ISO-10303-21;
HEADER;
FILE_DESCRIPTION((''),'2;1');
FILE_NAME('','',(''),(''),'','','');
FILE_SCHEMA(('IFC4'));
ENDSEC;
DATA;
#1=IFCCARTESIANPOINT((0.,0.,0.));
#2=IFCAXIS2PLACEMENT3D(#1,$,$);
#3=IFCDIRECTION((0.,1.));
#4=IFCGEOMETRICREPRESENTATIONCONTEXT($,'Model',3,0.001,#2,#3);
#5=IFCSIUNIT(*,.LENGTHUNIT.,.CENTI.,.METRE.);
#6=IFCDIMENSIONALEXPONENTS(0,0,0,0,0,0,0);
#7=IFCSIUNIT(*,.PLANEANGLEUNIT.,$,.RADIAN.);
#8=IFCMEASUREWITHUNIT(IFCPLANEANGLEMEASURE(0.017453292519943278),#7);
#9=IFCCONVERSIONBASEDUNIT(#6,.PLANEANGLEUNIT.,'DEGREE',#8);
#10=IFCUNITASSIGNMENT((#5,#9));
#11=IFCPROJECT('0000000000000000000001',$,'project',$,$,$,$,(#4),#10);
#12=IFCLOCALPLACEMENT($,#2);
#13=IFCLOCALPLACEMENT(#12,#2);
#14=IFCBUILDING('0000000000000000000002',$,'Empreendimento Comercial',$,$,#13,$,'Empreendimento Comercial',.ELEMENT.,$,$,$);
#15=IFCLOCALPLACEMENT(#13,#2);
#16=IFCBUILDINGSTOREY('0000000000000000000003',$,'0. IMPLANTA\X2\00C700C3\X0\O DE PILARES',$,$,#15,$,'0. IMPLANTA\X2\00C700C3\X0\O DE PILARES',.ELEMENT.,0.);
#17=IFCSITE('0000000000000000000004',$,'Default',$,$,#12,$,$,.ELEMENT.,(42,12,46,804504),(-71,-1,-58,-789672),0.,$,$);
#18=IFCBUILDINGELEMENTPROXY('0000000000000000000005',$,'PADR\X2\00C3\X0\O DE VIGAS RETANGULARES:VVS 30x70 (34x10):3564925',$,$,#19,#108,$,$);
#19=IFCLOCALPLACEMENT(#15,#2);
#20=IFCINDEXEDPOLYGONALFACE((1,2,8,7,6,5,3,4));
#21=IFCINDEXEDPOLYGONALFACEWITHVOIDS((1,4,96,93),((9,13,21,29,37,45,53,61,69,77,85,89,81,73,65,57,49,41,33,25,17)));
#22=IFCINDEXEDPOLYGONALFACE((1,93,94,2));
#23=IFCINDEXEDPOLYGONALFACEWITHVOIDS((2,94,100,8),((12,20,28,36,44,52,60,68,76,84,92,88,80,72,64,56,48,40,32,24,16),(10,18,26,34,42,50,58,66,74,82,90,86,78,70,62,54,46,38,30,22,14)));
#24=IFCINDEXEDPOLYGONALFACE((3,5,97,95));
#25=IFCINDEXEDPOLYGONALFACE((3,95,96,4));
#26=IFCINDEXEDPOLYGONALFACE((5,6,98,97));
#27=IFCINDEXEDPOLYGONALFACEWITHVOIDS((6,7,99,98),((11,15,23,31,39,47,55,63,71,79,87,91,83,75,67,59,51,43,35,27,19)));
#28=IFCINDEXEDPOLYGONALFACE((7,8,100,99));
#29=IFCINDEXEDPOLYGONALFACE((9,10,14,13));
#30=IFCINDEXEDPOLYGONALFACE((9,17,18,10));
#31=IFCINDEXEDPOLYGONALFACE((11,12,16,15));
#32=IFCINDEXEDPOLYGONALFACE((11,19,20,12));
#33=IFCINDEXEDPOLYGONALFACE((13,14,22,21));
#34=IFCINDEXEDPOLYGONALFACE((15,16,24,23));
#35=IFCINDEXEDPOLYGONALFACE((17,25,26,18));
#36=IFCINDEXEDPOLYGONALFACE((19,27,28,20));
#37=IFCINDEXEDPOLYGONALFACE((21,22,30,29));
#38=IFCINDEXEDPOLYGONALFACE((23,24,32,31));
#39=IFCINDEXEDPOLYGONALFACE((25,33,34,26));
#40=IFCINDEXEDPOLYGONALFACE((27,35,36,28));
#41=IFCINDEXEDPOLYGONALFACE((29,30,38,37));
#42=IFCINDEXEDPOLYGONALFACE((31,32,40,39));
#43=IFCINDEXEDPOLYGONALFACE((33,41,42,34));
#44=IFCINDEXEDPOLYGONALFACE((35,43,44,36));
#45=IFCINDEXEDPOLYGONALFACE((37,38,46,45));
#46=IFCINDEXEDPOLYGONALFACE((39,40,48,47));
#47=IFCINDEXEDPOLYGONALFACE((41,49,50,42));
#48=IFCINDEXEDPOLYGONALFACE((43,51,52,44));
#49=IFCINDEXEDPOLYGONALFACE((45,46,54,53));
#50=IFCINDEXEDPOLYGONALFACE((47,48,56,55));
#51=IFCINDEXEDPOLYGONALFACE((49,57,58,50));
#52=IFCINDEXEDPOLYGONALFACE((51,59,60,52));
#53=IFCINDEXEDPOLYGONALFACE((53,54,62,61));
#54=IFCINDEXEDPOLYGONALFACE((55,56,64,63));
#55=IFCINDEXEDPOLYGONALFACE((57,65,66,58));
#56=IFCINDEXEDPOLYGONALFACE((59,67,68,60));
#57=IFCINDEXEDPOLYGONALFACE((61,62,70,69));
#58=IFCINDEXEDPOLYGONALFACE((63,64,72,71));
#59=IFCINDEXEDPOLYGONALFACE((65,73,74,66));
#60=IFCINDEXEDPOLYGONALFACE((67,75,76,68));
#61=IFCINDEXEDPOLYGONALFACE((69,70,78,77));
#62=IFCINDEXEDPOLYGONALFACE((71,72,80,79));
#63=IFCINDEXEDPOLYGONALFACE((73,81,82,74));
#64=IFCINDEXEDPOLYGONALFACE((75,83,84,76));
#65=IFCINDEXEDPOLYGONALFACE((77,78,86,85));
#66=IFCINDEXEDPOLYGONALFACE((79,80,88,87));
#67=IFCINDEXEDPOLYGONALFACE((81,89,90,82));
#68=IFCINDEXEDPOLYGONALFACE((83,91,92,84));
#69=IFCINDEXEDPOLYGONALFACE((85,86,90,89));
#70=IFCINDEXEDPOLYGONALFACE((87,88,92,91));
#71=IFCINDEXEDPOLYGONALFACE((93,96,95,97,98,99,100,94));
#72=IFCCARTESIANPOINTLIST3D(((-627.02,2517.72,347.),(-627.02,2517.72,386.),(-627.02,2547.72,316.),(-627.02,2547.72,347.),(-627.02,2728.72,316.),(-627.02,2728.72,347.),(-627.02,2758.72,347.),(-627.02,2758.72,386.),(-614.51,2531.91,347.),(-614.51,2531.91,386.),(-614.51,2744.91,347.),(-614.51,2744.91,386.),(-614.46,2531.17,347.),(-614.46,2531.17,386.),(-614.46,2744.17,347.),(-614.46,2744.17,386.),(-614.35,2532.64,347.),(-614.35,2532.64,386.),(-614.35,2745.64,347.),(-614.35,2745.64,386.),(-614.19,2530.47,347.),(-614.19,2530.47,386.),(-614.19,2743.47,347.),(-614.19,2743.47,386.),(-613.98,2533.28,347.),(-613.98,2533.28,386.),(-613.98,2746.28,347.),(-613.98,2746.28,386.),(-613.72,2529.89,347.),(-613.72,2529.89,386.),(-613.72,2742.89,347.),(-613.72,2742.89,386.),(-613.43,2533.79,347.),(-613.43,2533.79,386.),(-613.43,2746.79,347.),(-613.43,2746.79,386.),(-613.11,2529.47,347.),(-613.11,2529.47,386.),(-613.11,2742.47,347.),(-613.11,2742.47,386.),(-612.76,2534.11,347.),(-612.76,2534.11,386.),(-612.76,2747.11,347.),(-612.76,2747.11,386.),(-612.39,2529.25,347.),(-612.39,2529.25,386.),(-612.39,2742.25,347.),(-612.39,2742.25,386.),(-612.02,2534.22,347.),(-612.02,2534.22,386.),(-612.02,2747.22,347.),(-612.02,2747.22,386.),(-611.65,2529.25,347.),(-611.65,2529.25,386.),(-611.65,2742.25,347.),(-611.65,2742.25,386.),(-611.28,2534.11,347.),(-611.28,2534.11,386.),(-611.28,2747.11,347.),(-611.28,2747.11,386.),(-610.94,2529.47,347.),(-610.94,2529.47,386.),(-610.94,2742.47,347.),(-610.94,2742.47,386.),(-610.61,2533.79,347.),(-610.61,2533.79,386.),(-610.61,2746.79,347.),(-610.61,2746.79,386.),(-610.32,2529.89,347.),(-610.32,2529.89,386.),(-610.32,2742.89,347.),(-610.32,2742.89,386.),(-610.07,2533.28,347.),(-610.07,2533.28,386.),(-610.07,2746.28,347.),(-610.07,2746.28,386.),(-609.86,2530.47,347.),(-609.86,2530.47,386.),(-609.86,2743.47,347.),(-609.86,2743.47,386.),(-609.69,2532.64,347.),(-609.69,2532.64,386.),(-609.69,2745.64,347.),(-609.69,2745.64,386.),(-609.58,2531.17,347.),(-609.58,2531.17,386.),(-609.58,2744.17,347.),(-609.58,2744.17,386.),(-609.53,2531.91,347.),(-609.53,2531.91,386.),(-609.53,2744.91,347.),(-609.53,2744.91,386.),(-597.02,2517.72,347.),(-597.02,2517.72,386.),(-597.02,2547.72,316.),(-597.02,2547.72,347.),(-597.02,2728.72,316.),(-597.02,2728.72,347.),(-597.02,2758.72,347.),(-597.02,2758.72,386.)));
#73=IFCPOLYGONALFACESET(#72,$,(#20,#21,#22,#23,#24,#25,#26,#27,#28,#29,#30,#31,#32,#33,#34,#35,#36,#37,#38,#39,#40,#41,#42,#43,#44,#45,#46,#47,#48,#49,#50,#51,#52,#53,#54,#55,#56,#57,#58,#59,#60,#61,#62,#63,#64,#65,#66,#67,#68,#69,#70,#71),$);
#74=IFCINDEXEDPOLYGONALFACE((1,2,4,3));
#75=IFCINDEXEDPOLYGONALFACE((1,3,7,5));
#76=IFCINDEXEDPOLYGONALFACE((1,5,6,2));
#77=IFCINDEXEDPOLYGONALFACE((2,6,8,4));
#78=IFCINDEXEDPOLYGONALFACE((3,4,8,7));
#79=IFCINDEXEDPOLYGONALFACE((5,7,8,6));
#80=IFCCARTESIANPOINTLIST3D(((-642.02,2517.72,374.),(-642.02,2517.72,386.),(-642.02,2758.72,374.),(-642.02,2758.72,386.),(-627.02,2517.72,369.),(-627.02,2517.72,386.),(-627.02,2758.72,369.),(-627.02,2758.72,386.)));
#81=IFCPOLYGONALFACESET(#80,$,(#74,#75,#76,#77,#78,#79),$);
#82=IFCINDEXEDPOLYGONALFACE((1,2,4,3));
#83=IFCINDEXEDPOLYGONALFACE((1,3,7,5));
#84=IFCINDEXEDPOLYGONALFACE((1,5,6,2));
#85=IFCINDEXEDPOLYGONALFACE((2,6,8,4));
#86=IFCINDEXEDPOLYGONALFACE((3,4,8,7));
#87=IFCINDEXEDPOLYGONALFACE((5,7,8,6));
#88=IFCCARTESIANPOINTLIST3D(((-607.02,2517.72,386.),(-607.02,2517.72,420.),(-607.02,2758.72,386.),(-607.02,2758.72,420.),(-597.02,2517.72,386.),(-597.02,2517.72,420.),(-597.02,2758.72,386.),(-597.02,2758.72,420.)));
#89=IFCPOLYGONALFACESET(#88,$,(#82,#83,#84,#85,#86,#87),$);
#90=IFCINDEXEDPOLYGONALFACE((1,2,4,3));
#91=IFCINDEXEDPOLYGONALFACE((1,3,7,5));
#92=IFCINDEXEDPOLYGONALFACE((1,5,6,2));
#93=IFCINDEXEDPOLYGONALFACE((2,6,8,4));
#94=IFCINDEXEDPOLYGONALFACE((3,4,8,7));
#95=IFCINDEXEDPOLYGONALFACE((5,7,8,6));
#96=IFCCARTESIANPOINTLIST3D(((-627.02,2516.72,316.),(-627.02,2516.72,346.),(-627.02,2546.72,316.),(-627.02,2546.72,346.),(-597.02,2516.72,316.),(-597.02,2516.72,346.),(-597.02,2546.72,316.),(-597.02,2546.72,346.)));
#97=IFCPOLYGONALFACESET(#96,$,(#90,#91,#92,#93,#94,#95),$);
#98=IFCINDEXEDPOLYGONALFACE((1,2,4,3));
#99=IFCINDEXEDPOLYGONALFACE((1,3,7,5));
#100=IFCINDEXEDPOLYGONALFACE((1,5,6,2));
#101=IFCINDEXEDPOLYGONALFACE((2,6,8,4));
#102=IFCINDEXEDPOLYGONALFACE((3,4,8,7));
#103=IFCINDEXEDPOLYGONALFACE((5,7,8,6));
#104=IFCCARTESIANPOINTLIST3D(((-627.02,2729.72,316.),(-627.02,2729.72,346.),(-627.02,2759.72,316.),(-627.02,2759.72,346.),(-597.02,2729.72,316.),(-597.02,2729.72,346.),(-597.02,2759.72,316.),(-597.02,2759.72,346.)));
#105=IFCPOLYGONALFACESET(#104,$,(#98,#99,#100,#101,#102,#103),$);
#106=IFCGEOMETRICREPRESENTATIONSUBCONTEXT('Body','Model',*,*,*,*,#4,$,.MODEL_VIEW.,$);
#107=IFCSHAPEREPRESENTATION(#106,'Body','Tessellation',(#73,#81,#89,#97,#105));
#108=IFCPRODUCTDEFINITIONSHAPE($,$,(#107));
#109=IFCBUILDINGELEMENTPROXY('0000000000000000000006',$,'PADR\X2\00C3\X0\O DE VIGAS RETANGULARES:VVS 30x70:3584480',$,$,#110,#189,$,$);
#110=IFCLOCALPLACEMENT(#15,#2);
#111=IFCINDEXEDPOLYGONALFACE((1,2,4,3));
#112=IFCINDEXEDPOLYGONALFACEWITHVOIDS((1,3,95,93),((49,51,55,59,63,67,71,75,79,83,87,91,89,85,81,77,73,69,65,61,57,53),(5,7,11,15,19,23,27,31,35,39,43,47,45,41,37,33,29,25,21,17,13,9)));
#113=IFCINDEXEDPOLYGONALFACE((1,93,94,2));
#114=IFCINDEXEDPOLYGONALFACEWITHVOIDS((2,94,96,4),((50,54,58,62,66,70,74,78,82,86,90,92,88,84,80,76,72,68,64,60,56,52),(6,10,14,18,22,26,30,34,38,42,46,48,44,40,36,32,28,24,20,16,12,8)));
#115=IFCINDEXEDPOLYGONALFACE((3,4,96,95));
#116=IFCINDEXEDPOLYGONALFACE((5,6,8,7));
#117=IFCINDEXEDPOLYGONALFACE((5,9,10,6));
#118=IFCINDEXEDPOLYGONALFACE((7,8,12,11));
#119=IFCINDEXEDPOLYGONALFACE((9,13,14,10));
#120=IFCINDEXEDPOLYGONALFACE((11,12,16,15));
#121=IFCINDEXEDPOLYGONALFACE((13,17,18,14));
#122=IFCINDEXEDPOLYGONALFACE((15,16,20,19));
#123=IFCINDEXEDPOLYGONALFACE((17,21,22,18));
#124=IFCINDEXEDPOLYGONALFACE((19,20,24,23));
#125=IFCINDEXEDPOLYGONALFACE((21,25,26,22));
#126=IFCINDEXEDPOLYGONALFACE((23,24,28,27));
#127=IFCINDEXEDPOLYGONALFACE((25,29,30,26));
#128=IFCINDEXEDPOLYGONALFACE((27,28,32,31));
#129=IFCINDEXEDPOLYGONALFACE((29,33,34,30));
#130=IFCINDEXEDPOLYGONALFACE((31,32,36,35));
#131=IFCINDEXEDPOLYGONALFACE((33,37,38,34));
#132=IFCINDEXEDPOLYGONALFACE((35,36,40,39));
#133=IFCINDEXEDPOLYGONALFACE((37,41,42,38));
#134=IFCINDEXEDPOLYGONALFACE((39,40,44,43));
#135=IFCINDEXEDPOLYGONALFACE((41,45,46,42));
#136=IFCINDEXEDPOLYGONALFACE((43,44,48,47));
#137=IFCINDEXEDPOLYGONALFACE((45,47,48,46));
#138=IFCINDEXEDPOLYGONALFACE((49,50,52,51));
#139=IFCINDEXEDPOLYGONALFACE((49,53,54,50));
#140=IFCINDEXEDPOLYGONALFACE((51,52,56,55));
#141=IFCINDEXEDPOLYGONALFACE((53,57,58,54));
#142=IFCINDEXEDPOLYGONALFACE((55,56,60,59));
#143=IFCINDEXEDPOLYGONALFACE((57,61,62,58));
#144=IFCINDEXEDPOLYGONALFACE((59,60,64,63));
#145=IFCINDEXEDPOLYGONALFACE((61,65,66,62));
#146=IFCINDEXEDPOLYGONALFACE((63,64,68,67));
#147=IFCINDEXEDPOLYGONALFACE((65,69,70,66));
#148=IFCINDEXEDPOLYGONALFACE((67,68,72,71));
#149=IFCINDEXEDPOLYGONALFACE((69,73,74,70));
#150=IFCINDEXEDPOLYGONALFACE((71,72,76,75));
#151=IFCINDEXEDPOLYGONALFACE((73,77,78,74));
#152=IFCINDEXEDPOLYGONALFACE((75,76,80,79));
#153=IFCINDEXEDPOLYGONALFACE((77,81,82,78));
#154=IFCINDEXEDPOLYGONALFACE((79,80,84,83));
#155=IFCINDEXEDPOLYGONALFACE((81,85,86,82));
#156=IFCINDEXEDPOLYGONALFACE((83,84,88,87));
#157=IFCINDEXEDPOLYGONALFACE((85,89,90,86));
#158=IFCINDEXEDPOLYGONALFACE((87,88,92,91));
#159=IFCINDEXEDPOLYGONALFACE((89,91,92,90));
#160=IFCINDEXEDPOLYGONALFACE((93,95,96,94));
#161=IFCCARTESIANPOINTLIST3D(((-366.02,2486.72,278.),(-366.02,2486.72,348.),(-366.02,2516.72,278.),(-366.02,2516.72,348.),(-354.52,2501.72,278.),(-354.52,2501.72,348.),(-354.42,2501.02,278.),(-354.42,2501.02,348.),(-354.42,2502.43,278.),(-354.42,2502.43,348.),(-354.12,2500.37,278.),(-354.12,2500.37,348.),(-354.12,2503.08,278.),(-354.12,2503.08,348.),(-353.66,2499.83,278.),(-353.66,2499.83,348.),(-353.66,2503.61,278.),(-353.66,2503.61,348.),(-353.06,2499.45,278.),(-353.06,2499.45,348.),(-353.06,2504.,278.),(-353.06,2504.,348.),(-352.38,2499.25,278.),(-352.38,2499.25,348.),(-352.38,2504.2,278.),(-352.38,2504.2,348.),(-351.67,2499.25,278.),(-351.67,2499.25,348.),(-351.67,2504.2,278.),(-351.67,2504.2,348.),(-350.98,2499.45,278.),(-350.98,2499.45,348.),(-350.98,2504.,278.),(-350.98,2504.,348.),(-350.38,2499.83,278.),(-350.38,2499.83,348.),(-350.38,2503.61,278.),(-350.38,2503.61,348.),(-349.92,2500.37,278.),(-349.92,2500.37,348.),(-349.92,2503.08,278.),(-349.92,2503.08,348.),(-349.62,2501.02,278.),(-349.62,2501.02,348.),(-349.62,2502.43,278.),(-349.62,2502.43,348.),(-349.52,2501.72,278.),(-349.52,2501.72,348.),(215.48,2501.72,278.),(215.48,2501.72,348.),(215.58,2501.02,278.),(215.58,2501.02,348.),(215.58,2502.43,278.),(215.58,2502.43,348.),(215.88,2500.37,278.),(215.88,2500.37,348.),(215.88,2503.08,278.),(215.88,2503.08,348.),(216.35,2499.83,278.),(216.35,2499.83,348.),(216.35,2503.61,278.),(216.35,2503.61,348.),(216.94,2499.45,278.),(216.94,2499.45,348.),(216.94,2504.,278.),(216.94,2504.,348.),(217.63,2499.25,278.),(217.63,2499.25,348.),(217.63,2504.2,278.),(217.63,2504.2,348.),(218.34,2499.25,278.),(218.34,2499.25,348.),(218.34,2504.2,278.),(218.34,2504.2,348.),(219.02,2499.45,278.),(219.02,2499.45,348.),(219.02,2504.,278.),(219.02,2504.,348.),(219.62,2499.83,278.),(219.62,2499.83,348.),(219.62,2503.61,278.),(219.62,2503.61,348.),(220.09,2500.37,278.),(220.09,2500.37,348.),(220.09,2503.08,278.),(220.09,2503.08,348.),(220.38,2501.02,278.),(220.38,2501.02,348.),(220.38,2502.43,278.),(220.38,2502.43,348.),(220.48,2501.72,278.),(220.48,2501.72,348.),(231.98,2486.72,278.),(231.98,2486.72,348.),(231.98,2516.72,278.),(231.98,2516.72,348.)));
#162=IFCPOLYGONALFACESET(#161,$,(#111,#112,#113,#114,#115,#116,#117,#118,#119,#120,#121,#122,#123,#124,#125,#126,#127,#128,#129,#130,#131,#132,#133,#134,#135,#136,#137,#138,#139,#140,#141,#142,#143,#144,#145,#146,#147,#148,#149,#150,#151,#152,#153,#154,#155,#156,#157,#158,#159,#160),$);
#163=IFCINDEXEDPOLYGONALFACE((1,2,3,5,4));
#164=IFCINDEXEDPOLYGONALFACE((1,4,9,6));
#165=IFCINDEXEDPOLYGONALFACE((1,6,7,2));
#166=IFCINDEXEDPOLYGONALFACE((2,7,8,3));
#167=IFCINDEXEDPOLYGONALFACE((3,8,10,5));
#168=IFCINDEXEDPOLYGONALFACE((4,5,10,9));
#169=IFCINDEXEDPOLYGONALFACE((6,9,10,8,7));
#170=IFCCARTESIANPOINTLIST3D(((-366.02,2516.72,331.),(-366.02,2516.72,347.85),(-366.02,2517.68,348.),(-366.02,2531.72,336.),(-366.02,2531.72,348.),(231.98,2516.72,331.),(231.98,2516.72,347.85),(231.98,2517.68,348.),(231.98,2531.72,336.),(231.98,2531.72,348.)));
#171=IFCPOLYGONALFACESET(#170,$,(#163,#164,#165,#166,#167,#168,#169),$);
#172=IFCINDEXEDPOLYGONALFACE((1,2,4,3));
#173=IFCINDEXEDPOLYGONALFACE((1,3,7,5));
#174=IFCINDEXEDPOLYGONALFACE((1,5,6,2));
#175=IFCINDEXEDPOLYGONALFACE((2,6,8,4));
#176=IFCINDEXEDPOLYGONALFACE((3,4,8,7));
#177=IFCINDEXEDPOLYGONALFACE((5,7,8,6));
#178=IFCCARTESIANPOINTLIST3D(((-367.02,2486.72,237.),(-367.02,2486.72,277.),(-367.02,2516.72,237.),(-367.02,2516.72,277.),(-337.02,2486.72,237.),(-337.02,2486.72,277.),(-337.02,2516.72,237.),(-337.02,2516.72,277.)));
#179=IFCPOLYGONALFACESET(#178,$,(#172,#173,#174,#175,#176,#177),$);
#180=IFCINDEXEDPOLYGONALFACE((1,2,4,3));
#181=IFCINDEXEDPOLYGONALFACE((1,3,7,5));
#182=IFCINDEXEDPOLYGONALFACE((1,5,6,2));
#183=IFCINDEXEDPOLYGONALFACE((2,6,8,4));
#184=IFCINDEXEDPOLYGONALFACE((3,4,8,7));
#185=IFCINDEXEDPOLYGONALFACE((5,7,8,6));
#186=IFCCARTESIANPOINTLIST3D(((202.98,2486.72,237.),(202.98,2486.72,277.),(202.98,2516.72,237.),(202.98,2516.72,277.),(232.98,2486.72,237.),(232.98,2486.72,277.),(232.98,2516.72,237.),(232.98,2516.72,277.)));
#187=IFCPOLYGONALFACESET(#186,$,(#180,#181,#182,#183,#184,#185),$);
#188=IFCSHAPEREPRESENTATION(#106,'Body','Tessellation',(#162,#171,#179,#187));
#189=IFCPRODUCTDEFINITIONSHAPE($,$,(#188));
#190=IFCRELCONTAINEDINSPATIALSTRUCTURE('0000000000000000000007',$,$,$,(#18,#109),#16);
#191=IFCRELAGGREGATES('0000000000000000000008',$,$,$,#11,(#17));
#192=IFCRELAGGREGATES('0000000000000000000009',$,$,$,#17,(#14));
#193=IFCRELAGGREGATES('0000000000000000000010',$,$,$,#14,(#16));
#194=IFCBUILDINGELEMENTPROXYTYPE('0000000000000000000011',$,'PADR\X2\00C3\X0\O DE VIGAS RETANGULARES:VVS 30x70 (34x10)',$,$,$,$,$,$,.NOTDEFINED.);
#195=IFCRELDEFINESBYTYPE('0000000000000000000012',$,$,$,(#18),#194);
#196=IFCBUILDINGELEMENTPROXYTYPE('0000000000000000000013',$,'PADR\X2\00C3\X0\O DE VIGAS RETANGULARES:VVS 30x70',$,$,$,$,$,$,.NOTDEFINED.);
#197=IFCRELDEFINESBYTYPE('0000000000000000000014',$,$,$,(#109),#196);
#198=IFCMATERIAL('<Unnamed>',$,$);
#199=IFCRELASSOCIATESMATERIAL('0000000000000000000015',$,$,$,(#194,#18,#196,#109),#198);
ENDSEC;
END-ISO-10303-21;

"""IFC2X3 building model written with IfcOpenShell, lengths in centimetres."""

from ifc_helpers import new_model, entity, si_unit, converted_unit, direction, frame, frame_2d, origin, origin_2d_with_axis, place, context, subcontext, project, spatial, polyline, circle_curve, parameter, trimmed, segment, composite_curve, rectangle, circle, outline, extrude, source, transform, mapped, material, type_object, type_shapes, element, save


model = new_model("IFC2X3")

# Units and contexts
model_context = context("Model", 3, precision=0.001, world=origin(), true_north=direction((0.0, 1.0)))
body_context = subcontext(model_context, "Body", "Model", "MODEL_VIEW")
ifc_project = project(units=[si_unit("LENGTHUNIT", "METRE", prefix="CENTI"), converted_unit("PLANEANGLEUNIT", "DEGREE", entity("IfcPlaneAngleMeasure", 0.017453292519943278), si_unit("PLANEANGLEUNIT", "RADIAN"), dimensions=[0, 0, 0, 0, 0, 0, 0])], contexts=[model_context])

# Site, building, storey
site_placement = place(None, origin())
site = spatial("IfcSite", under=ifc_project, at=site_placement, Name="Default", CompositionType="ELEMENT", RefLatitude=(42, 12, 46, 804504), RefLongitude=(-71, -1, -58, -789672), RefElevation=0.0)
building_placement = place(site_placement, origin())
building = spatial("IfcBuilding", under=site, at=building_placement, Name="Empreendimento Comercial", LongName="Empreendimento Comercial", CompositionType="ELEMENT")
storey_placement = place(building_placement, origin())
storey = spatial("IfcBuildingStorey", under=building, at=storey_placement, Name="0. IMPLANTAÇÃO DE PILARES", LongName="0. IMPLANTAÇÃO DE PILARES", CompositionType="ELEMENT", Elevation=0.0)

# Shared definitions
ifc_material_1 = material(Name="<Unnamed>")

# Building element proxy, openings
building_element_proxy_type_1 = type_object("IfcBuildingElementProxyType", Name="PADRÃO DE VIGAS RETANGULARES:VVS 30x70 (34x10)", PredefinedType="NOTDEFINED", material=ifc_material_1)
shared_shape_1 = source(origin(), body_context, "Body", "SweptSolid", [
    extrude(outline(polyline([(-120.5, -37.0), (120.5, -37.0), (120.5, 2.0), (90.5, 2.0), (90.5, 33.0), (-90.5, 33.0), (-90.5, 2.0), (-120.5, 2.0), (-120.5, -37.0)])), frame((-627.02, 2638.22, 349.0), z_axis=(1.0, 0.0, 0.0), x_axis=(0.0, -1.0, 0.0)), (0.0, 0.0, 1.0), 30.0),
    extrude(outline(polyline([(-7.5, -7.25), (7.5, -7.25), (7.5, 9.75), (-7.5, 4.75), (-7.5, -7.25)])), frame((-634.52, 2517.72, 378.75), z_axis=(0.0, 1.0, 0.0), x_axis=(1.0, 0.0, 0.0)), (0.0, 0.0, 1.0), 241.0),
    extrude(rectangle(XDim=10.0, YDim=241.0, at=frame_2d((0.0, 0.0), x_axis=(1.0, 0.0))), frame((-602.02, 2638.22, 386.0), z_axis=(0.0, 0.0, 1.0), x_axis=(-1.0, 0.0, 0.0)), (0.0, 0.0, 1.0), 34.0),
    extrude(rectangle(XDim=30.0, YDim=30.0, at=frame_2d((0.0, 0.0), x_axis=(1.0, 0.0))), frame((-612.02, 2531.72, 316.0), z_axis=(0.0, 0.0, 1.0), x_axis=(0.0, -1.0, 0.0)), (0.0, 0.0, 1.0), 30.0),
    extrude(rectangle(XDim=30.0, YDim=30.0, at=frame_2d((0.0, 0.0), x_axis=(1.0, 0.0))), frame((-612.02, 2744.72, 316.0), z_axis=(0.0, 0.0, 1.0), x_axis=(0.0, -1.0, 0.0)), (0.0, 0.0, 1.0), 30.0),
])
type_shapes(building_element_proxy_type_1, [shared_shape_1])
proxy_1_placement = place(storey_placement, origin())
proxy_1 = element("IfcBuildingElementProxy", 1, at=proxy_1_placement, inside=storey, type_object=building_element_proxy_type_1, material=ifc_material_1, Name="PADRÃO DE VIGAS RETANGULARES:VVS 30x70 (34x10):3564925", context=body_context, shape_type="MappedRepresentation", body=[
    mapped(shared_shape_1, transform((0.0, 0.0, 0.0), scale=1.0)),
])
opening_1_placement = place(storey_placement, origin())
element("IfcOpeningElement", 2, at=opening_1_placement, cuts=proxy_1, ObjectType="Opening", context=body_context, shape_type="SweptSolid", body=[
    extrude(circle(Radius=2.5, at=origin_2d_with_axis()), frame((-612.02, 2744.72, 386.0), z_axis=(0.0, 0.0, -1.0), x_axis=(0.0, 1.0, 0.0)), (0.0, 0.0, 1.0), 39.0),
])
opening_2_placement = place(storey_placement, origin())
element("IfcOpeningElement", 3, at=opening_2_placement, cuts=proxy_1, ObjectType="Opening", context=body_context, shape_type="SweptSolid", body=[
    extrude(circle(Radius=2.5, at=origin_2d_with_axis()), frame((-612.02, 2531.72, 347.0), z_axis=(0.0, 0.0, 1.0), x_axis=(0.0, 1.0, 0.0)), (0.0, 0.0, 1.0), 39.0),
])

# Building element proxy
building_element_proxy_type_2 = type_object("IfcBuildingElementProxyType", Name="PADRÃO DE VIGAS RETANGULARES:VVS 30x70", PredefinedType="NOTDEFINED", material=ifc_material_1)
shared_shape_2 = source(origin(), body_context, "Body", "SweptSolid", [
    extrude(outline(polyline([(-15.0, -299.0), (15.0, -299.0), (15.0, 299.0), (-15.0, 299.0), (-15.0, -299.0)]), holes=[composite_curve([segment(trimmed(circle_curve(frame_2d((0.0, 285.0), x_axis=(0.0, -1.0)), 2.5), [parameter(0.0)], [parameter(180.0)], True, "PARAMETER"), False, "CONTINUOUS"), segment(trimmed(circle_curve(frame_2d((0.0, 285.0), x_axis=(0.0, -1.0)), 2.5), [parameter(180.0)], [parameter(0.0)], True, "PARAMETER"), False, "CONTINUOUS")], self_intersect=False), composite_curve([segment(trimmed(circle_curve(frame_2d((0.0, -285.0), x_axis=(0.0, -1.0)), 2.5), [parameter(0.0)], [parameter(180.0)], True, "PARAMETER"), False, "CONTINUOUS"), segment(trimmed(circle_curve(frame_2d((0.0, -285.0), x_axis=(0.0, -1.0)), 2.5), [parameter(180.0)], [parameter(0.0)], True, "PARAMETER"), False, "CONTINUOUS")], self_intersect=False)]), frame((-67.02, 2501.72, 278.0), z_axis=(0.0, 0.0, 1.0), x_axis=(0.0, 1.0, 0.0)), (0.0, 0.0, 1.0), 70.0),
    extrude(outline(polyline([(-6.17, -8.81), (5.83, -8.81), (5.83, 5.23), (5.68, 6.19), (-11.17, 6.19), (-6.17, -8.81)])), frame((-366.02, 2522.92, 342.17), z_axis=(1.0, 0.0, 0.0), x_axis=(0.0, 0.0, 1.0)), (0.0, 0.0, 1.0), 598.0),
    extrude(rectangle(XDim=30.0, YDim=30.0, at=frame_2d((0.0, 0.0), x_axis=(1.0, 0.0))), frame((-352.02, 2501.72, 237.0), z_axis=(0.0, 0.0, 1.0), x_axis=(-1.0, 0.0, 0.0)), (0.0, 0.0, 1.0), 40.0),
    extrude(rectangle(XDim=30.0, YDim=30.0, at=frame_2d((0.0, 0.0), x_axis=(1.0, 0.0))), frame((217.98, 2501.72, 237.0), z_axis=(0.0, 0.0, 1.0), x_axis=(-1.0, 0.0, 0.0)), (0.0, 0.0, 1.0), 40.0),
])
type_shapes(building_element_proxy_type_2, [shared_shape_2])
proxy_2_placement = place(storey_placement, origin())
element("IfcBuildingElementProxy", 4, at=proxy_2_placement, inside=storey, type_object=building_element_proxy_type_2, material=ifc_material_1, Name="PADRÃO DE VIGAS RETANGULARES:VVS 30x70:3584480", context=body_context, shape_type="MappedRepresentation", body=[
    mapped(shared_shape_2, transform((0.0, 0.0, 0.0), scale=1.0)),
])

save(model, "model.ifc")
